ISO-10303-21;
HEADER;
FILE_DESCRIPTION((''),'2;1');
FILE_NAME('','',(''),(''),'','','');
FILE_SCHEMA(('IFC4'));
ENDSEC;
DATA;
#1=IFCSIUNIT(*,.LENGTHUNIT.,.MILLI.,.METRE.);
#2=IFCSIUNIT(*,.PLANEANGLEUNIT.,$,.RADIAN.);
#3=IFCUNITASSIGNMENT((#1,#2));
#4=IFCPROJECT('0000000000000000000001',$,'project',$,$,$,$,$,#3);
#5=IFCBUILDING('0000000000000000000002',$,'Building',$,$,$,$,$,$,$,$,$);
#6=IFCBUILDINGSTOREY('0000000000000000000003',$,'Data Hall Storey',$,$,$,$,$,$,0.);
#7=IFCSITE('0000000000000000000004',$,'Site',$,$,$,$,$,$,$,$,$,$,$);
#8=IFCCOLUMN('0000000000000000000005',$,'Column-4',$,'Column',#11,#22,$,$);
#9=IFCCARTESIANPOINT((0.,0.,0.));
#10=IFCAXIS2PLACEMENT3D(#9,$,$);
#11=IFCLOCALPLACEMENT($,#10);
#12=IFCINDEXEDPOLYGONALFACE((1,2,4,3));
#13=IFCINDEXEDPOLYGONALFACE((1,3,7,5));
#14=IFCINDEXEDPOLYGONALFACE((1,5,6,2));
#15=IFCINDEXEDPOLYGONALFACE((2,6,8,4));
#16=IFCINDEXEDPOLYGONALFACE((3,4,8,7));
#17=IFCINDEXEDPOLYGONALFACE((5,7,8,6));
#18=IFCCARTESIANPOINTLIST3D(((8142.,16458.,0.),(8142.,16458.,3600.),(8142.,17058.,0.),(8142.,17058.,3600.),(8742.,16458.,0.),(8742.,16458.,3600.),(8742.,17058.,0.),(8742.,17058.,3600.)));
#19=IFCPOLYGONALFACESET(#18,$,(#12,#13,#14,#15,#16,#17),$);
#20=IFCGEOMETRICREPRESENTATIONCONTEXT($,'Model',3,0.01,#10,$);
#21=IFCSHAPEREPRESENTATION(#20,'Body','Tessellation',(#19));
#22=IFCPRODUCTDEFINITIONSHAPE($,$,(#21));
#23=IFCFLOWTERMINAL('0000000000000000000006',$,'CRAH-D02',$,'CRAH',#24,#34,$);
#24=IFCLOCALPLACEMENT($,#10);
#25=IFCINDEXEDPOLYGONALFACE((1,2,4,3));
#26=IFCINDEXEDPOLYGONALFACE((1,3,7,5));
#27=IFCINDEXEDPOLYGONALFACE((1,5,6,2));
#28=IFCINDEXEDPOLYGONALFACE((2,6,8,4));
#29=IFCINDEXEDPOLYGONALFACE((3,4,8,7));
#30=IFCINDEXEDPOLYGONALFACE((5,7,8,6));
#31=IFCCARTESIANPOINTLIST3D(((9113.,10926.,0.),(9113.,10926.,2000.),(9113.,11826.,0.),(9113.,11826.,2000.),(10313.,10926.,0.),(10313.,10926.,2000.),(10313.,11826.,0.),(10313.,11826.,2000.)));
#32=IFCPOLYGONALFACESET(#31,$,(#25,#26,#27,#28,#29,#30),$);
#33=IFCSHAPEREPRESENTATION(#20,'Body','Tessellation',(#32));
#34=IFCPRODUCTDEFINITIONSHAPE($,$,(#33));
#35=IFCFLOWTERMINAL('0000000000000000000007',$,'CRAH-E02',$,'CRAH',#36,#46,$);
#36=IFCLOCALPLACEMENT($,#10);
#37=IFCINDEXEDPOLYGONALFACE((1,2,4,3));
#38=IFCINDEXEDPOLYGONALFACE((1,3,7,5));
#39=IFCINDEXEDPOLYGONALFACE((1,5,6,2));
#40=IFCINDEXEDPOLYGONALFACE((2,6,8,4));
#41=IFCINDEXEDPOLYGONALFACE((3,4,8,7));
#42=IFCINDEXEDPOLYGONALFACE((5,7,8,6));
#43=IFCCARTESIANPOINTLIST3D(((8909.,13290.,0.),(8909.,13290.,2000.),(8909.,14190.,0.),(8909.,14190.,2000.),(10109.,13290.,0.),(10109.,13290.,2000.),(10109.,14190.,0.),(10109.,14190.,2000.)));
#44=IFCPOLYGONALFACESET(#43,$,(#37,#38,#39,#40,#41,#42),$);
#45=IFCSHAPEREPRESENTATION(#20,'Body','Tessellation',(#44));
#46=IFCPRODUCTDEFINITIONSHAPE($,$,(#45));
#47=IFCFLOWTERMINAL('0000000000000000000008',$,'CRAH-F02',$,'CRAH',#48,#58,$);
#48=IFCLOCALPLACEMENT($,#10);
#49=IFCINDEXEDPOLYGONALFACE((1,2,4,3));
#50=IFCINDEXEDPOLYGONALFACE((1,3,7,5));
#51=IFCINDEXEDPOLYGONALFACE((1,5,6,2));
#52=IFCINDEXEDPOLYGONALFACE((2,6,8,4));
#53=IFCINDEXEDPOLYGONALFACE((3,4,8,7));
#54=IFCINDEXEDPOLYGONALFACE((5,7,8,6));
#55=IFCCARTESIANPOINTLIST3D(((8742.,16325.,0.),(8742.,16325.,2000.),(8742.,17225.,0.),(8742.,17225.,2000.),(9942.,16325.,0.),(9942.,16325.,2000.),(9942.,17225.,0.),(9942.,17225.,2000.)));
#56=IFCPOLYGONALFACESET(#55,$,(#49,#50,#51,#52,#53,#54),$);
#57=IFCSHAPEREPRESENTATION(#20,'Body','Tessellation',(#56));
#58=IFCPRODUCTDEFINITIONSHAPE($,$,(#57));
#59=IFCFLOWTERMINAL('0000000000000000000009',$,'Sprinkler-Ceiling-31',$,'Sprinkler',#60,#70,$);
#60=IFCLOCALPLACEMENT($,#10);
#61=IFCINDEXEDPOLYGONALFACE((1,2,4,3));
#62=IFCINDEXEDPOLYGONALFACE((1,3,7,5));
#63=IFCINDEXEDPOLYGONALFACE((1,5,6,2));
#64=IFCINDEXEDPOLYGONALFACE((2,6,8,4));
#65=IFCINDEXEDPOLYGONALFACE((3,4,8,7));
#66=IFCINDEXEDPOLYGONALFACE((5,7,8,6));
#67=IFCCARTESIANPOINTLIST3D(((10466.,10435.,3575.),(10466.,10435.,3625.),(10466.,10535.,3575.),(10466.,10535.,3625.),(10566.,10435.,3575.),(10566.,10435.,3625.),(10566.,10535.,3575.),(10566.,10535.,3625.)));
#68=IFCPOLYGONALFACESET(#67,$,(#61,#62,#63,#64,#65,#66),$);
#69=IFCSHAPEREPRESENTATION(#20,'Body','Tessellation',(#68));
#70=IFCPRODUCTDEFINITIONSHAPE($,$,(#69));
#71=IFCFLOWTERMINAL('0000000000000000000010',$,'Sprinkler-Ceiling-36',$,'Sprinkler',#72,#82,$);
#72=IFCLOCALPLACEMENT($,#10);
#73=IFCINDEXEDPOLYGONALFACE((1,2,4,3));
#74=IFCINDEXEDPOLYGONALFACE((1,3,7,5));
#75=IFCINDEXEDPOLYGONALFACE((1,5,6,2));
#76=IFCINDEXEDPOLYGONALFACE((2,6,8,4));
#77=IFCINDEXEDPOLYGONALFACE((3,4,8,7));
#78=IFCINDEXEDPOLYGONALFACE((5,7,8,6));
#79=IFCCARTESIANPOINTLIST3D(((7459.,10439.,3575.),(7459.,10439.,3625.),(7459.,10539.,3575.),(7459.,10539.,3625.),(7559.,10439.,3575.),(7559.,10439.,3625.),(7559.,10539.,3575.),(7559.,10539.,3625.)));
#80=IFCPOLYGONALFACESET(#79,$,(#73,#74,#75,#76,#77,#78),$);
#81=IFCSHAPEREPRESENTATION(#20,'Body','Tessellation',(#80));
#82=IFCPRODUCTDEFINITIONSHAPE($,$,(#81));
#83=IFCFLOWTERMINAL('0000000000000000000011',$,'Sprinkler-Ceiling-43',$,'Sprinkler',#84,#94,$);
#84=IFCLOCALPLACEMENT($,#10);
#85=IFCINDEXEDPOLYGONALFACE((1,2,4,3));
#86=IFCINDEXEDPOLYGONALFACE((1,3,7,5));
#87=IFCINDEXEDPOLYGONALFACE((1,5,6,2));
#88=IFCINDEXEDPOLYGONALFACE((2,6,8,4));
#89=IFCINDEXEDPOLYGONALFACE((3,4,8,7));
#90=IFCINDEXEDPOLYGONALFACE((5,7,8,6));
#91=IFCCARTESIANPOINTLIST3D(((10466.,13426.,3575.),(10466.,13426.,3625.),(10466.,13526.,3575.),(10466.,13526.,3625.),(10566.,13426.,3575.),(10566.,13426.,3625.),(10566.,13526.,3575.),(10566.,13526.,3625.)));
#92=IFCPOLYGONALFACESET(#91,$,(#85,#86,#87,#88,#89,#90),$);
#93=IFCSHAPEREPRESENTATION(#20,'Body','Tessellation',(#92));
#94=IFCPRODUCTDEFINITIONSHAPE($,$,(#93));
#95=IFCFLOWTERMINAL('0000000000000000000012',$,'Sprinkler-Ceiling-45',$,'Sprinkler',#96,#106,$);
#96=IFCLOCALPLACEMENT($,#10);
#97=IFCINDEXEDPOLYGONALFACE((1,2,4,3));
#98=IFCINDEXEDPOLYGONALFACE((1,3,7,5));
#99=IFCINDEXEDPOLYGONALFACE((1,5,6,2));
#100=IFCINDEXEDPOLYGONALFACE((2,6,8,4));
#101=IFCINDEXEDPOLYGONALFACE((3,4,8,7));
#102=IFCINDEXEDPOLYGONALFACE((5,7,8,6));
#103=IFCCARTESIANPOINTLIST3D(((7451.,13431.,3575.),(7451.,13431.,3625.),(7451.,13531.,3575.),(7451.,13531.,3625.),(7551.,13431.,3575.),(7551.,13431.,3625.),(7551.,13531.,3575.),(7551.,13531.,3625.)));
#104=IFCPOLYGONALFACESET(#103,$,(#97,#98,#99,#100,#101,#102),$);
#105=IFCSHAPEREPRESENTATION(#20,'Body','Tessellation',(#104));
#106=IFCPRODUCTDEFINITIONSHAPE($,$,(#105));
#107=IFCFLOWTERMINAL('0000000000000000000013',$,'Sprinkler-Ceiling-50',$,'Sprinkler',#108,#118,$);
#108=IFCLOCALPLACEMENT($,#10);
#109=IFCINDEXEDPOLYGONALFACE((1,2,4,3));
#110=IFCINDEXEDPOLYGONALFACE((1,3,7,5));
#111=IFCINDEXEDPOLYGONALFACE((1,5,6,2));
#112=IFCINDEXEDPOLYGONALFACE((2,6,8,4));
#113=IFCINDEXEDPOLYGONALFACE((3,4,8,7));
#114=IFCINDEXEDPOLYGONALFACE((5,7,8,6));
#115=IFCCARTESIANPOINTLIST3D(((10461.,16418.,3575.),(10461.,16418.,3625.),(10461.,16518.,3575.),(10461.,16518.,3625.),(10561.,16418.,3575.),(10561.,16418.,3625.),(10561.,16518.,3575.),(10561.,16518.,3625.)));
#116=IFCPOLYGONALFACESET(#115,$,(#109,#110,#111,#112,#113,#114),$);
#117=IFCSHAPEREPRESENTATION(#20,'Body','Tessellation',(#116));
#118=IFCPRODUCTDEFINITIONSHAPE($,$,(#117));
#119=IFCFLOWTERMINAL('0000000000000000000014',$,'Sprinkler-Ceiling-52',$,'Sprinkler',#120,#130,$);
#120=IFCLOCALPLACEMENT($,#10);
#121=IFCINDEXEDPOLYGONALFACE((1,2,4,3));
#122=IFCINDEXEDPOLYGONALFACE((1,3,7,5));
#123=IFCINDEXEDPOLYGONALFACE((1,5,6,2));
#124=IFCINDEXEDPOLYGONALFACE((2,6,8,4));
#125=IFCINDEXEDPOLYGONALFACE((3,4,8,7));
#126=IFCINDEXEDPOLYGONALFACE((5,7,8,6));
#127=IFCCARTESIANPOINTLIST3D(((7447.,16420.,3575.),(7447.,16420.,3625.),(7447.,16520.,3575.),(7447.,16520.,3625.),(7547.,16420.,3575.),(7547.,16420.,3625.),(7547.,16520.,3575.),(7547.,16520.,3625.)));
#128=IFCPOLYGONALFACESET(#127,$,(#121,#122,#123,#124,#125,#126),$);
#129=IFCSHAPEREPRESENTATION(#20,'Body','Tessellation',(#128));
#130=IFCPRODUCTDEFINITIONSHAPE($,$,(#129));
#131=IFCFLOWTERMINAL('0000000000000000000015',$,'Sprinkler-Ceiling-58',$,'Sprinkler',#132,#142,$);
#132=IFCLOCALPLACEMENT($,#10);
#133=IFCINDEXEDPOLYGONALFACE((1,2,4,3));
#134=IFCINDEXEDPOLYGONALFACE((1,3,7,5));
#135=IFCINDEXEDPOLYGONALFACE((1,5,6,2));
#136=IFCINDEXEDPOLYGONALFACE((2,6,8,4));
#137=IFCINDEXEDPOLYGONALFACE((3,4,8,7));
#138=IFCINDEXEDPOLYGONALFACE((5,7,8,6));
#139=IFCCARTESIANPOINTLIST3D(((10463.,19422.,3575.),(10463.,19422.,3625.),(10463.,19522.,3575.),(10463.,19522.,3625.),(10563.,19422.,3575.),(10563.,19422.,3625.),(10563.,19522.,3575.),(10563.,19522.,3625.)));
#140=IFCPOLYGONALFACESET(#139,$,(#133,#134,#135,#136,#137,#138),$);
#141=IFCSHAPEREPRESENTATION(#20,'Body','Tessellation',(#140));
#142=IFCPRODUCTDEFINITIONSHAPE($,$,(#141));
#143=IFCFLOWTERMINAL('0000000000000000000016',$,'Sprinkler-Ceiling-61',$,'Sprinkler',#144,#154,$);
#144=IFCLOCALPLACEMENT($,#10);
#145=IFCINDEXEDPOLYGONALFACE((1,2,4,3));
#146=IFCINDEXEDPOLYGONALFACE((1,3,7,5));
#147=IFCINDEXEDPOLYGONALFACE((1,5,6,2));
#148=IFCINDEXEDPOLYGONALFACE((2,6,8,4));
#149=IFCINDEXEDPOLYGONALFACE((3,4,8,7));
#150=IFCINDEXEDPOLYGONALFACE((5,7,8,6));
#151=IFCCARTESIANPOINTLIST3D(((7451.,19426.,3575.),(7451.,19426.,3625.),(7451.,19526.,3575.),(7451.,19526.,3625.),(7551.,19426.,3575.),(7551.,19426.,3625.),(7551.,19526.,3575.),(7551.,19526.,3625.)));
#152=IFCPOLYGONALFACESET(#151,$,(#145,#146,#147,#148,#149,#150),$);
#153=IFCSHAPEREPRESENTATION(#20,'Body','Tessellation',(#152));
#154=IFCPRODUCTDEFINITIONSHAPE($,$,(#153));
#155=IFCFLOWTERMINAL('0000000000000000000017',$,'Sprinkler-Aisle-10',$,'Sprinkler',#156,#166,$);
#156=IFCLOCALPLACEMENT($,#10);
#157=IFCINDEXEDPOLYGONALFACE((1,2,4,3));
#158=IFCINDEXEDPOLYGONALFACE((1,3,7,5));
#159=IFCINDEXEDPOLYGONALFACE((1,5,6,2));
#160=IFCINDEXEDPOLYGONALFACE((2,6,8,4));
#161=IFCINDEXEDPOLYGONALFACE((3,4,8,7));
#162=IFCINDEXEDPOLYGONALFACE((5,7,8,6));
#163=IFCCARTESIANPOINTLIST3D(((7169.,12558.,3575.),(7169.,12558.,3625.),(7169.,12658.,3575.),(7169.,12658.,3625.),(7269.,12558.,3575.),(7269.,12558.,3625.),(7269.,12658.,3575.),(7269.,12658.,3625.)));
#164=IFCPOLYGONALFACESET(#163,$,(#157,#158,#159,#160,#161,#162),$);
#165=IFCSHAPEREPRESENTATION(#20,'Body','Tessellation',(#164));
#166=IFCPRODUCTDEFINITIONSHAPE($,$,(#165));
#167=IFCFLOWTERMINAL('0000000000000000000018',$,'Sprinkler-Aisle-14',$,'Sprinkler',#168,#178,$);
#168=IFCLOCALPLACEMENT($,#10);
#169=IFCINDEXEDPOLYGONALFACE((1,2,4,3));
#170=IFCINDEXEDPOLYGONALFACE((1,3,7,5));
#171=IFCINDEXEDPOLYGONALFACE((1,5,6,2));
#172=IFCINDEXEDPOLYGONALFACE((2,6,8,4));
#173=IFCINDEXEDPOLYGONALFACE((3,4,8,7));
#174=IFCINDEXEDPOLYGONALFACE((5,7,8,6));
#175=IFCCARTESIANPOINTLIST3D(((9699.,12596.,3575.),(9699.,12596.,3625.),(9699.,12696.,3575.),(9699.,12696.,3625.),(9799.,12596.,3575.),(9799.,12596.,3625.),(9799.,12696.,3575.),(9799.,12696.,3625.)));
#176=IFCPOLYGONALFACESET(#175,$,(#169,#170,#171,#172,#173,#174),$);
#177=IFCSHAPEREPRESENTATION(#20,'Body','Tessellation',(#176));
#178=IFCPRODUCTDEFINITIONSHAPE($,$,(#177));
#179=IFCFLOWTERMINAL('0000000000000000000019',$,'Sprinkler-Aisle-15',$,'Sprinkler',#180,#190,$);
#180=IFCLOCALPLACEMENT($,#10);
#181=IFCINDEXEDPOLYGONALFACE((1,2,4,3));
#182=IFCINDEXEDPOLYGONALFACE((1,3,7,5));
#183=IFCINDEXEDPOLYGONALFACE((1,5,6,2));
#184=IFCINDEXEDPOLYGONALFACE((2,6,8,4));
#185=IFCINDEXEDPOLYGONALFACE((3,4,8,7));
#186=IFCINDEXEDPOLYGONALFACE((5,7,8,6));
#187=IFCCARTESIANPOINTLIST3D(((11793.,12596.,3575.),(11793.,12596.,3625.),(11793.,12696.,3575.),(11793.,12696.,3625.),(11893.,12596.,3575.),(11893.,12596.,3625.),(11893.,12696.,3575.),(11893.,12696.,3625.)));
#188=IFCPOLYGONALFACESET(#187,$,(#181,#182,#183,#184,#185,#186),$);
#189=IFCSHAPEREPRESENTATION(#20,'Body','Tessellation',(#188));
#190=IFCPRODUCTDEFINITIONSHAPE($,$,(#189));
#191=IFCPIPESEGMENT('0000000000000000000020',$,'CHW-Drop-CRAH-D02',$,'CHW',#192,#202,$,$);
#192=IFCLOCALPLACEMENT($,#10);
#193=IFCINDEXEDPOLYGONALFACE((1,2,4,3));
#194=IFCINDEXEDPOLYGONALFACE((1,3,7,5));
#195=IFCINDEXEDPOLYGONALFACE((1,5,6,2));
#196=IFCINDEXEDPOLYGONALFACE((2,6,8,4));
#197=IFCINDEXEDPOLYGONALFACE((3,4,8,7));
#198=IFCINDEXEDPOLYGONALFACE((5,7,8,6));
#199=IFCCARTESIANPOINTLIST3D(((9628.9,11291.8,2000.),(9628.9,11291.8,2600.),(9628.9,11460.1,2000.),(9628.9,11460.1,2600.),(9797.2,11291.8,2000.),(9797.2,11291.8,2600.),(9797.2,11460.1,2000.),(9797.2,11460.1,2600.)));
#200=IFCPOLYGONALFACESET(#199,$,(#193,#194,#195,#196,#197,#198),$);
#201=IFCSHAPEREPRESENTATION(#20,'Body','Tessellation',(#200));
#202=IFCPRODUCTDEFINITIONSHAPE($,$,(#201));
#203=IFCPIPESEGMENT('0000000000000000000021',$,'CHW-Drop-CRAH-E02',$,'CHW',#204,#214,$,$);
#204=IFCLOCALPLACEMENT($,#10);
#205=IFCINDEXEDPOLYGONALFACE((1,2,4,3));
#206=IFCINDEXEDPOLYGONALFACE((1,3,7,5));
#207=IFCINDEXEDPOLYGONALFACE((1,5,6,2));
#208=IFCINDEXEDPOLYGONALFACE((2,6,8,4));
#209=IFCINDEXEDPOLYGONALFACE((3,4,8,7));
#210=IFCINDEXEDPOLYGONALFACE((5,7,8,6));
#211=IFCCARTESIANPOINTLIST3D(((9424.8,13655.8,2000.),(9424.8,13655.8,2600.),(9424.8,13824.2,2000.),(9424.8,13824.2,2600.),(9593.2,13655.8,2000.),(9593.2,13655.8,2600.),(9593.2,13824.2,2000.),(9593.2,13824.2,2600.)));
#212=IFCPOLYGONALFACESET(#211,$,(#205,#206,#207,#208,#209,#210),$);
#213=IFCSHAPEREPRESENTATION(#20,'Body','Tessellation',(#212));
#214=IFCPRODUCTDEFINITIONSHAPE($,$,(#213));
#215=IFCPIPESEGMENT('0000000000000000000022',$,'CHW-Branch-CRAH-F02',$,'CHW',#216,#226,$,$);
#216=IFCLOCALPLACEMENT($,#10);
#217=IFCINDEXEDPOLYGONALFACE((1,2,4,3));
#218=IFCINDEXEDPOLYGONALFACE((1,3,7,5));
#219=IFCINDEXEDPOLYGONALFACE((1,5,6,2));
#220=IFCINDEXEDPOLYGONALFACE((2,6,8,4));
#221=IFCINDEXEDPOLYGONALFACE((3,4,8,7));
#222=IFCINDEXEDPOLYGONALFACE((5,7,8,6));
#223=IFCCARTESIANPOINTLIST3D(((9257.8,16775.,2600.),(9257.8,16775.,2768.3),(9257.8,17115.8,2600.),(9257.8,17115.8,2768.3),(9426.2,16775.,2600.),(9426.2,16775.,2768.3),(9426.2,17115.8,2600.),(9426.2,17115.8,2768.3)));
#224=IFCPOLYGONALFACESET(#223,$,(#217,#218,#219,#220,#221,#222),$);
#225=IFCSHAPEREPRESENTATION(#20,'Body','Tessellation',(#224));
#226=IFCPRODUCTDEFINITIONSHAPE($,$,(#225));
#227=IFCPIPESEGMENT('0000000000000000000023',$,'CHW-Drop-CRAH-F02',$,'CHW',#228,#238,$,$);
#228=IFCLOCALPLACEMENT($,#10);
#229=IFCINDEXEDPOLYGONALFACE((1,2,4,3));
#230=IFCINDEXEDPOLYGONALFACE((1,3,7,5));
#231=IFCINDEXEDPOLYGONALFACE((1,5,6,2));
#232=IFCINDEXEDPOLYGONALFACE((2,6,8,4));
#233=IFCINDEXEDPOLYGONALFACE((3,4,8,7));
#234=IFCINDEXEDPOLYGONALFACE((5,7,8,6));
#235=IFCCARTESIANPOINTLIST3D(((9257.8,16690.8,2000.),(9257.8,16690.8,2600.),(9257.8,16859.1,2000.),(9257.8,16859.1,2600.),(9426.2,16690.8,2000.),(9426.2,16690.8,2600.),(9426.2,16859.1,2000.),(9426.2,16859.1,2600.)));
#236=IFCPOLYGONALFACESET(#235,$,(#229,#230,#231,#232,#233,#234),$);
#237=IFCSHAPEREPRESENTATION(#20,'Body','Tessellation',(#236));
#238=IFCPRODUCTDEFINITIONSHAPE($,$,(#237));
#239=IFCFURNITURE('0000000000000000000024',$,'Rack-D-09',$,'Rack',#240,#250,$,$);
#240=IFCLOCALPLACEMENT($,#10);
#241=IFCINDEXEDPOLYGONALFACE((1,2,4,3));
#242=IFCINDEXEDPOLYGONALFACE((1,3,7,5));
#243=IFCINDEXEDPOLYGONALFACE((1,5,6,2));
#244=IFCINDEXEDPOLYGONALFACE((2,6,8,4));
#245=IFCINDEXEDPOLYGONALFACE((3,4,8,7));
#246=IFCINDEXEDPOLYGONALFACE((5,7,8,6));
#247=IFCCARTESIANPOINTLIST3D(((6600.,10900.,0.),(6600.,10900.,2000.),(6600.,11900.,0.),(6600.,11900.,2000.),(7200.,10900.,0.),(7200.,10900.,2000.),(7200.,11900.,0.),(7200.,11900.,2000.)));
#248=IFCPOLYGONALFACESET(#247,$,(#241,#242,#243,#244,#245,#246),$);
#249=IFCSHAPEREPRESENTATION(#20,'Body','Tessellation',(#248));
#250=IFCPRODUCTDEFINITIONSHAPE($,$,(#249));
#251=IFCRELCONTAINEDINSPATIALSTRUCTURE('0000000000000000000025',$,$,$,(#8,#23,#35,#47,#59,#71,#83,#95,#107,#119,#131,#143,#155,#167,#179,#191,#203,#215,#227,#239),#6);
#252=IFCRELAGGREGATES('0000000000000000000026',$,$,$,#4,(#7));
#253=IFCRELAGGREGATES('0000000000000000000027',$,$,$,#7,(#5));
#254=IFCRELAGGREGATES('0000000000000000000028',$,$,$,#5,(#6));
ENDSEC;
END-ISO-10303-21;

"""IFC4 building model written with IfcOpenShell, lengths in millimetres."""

from ifc_helpers import new_model, si_unit, frame, origin, place, context, project, spatial, rectangle, extrude, element, save


model = new_model("IFC4")

# Units and contexts
model_context = context("Model", 3, precision=0.01, world=origin())
ifc_project = project(units=[si_unit("LENGTHUNIT", "METRE", prefix="MILLI"), si_unit("PLANEANGLEUNIT", "RADIAN")])

# Site, building, storey
site = spatial("IfcSite", under=ifc_project, Name="Site")
building = spatial("IfcBuilding", under=site, Name="Building")
storey = spatial("IfcBuildingStorey", under=building, Name="Data Hall Storey", Elevation=0.0)

# Column
column_placement = place(None, frame((8442.0, 16758.0, 0.0)))
element("IfcColumn", 1, at=column_placement, inside=storey, Name="Column-4", ObjectType="Column", context=model_context, shape_type="SweptSolid", body=[
    extrude(rectangle(XDim=600.0, YDim=600.0), origin(), (0.0, 0.0, 1.0), 3600.0),
])

# Flow terminals
for number, where, name in (
    (2, (9713.0, 11376.0, 0.0), "CRAH-D02"),
    (3, (9509.0, 13740.0, 0.0), "CRAH-E02"),
    (4, (9342.0, 16775.0, 0.0), "CRAH-F02"),
):
    element("IfcFlowTerminal", number, at=place(None, frame(where)), inside=storey, Name=name, ObjectType="CRAH", context=model_context, shape_type="SweptSolid", body=[
        extrude(rectangle(XDim=1200.0, YDim=900.0), origin(), (0.0, 0.0, 1.0), 2000.0),
    ])
for number, where, name in (
    (5, (10516.0, 10485.0, 3575.0), "Sprinkler-Ceiling-31"),
    (6, (7509.0, 10489.0, 3575.0), "Sprinkler-Ceiling-36"),
    (7, (10516.0, 13476.0, 3575.0), "Sprinkler-Ceiling-43"),
    (8, (7501.0, 13481.0, 3575.0), "Sprinkler-Ceiling-45"),
    (9, (10511.0, 16468.0, 3575.0), "Sprinkler-Ceiling-50"),
    (10, (7497.0, 16470.0, 3575.0), "Sprinkler-Ceiling-52"),
    (11, (10513.0, 19472.0, 3575.0), "Sprinkler-Ceiling-58"),
    (12, (7501.0, 19476.0, 3575.0), "Sprinkler-Ceiling-61"),
    (13, (7219.0, 12608.0, 3575.0), "Sprinkler-Aisle-10"),
    (14, (9749.0, 12646.0, 3575.0), "Sprinkler-Aisle-14"),
    (15, (11843.0, 12646.0, 3575.0), "Sprinkler-Aisle-15"),
):
    element("IfcFlowTerminal", number, at=place(None, frame(where)), inside=storey, Name=name, ObjectType="Sprinkler", context=model_context, shape_type="SweptSolid", body=[
        extrude(rectangle(XDim=100.0, YDim=100.0), origin(), (0.0, 0.0, 1.0), 50.0),
    ])

# Pipe segments
for number, where, name in (
    (16, (9713.0, 11376.0, 2000.0), "CHW-Drop-CRAH-D02"),
    (17, (9509.0, 13740.0, 2000.0), "CHW-Drop-CRAH-E02"),
):
    element("IfcPipeSegment", number, at=place(None, frame(where)), inside=storey, Name=name, ObjectType="CHW", context=model_context, shape_type="SweptSolid", body=[
        extrude(rectangle(XDim=168.3, YDim=168.3), origin(), (0.0, 0.0, 1.0), 600.0),
    ])
pipe_segment_1_placement = place(None, frame((9342.0, 16945.4, 2600.0)))
element("IfcPipeSegment", 18, at=pipe_segment_1_placement, inside=storey, Name="CHW-Branch-CRAH-F02", ObjectType="CHW", context=model_context, shape_type="SweptSolid", body=[
    extrude(rectangle(XDim=168.3, YDim=340.8), origin(), (0.0, 0.0, 1.0), 168.3),
])
pipe_segment_2_placement = place(None, frame((9342.0, 16775.0, 2000.0)))
element("IfcPipeSegment", 19, at=pipe_segment_2_placement, inside=storey, Name="CHW-Drop-CRAH-F02", ObjectType="CHW", context=model_context, shape_type="SweptSolid", body=[
    extrude(rectangle(XDim=168.3, YDim=168.3), origin(), (0.0, 0.0, 1.0), 600.0),
])

# Furniture
for number, where, name in (
    (20, (6900.0, 11400.0, 0.0), "Rack-D-09"),
):
    element("IfcFurniture", number, at=place(None, frame(where)), inside=storey, Name=name, ObjectType="Rack", context=model_context, shape_type="SweptSolid", body=[
        extrude(rectangle(XDim=600.0, YDim=1000.0), origin(), (0.0, 0.0, 1.0), 2000.0),
    ])

save(model, "model.ifc")
